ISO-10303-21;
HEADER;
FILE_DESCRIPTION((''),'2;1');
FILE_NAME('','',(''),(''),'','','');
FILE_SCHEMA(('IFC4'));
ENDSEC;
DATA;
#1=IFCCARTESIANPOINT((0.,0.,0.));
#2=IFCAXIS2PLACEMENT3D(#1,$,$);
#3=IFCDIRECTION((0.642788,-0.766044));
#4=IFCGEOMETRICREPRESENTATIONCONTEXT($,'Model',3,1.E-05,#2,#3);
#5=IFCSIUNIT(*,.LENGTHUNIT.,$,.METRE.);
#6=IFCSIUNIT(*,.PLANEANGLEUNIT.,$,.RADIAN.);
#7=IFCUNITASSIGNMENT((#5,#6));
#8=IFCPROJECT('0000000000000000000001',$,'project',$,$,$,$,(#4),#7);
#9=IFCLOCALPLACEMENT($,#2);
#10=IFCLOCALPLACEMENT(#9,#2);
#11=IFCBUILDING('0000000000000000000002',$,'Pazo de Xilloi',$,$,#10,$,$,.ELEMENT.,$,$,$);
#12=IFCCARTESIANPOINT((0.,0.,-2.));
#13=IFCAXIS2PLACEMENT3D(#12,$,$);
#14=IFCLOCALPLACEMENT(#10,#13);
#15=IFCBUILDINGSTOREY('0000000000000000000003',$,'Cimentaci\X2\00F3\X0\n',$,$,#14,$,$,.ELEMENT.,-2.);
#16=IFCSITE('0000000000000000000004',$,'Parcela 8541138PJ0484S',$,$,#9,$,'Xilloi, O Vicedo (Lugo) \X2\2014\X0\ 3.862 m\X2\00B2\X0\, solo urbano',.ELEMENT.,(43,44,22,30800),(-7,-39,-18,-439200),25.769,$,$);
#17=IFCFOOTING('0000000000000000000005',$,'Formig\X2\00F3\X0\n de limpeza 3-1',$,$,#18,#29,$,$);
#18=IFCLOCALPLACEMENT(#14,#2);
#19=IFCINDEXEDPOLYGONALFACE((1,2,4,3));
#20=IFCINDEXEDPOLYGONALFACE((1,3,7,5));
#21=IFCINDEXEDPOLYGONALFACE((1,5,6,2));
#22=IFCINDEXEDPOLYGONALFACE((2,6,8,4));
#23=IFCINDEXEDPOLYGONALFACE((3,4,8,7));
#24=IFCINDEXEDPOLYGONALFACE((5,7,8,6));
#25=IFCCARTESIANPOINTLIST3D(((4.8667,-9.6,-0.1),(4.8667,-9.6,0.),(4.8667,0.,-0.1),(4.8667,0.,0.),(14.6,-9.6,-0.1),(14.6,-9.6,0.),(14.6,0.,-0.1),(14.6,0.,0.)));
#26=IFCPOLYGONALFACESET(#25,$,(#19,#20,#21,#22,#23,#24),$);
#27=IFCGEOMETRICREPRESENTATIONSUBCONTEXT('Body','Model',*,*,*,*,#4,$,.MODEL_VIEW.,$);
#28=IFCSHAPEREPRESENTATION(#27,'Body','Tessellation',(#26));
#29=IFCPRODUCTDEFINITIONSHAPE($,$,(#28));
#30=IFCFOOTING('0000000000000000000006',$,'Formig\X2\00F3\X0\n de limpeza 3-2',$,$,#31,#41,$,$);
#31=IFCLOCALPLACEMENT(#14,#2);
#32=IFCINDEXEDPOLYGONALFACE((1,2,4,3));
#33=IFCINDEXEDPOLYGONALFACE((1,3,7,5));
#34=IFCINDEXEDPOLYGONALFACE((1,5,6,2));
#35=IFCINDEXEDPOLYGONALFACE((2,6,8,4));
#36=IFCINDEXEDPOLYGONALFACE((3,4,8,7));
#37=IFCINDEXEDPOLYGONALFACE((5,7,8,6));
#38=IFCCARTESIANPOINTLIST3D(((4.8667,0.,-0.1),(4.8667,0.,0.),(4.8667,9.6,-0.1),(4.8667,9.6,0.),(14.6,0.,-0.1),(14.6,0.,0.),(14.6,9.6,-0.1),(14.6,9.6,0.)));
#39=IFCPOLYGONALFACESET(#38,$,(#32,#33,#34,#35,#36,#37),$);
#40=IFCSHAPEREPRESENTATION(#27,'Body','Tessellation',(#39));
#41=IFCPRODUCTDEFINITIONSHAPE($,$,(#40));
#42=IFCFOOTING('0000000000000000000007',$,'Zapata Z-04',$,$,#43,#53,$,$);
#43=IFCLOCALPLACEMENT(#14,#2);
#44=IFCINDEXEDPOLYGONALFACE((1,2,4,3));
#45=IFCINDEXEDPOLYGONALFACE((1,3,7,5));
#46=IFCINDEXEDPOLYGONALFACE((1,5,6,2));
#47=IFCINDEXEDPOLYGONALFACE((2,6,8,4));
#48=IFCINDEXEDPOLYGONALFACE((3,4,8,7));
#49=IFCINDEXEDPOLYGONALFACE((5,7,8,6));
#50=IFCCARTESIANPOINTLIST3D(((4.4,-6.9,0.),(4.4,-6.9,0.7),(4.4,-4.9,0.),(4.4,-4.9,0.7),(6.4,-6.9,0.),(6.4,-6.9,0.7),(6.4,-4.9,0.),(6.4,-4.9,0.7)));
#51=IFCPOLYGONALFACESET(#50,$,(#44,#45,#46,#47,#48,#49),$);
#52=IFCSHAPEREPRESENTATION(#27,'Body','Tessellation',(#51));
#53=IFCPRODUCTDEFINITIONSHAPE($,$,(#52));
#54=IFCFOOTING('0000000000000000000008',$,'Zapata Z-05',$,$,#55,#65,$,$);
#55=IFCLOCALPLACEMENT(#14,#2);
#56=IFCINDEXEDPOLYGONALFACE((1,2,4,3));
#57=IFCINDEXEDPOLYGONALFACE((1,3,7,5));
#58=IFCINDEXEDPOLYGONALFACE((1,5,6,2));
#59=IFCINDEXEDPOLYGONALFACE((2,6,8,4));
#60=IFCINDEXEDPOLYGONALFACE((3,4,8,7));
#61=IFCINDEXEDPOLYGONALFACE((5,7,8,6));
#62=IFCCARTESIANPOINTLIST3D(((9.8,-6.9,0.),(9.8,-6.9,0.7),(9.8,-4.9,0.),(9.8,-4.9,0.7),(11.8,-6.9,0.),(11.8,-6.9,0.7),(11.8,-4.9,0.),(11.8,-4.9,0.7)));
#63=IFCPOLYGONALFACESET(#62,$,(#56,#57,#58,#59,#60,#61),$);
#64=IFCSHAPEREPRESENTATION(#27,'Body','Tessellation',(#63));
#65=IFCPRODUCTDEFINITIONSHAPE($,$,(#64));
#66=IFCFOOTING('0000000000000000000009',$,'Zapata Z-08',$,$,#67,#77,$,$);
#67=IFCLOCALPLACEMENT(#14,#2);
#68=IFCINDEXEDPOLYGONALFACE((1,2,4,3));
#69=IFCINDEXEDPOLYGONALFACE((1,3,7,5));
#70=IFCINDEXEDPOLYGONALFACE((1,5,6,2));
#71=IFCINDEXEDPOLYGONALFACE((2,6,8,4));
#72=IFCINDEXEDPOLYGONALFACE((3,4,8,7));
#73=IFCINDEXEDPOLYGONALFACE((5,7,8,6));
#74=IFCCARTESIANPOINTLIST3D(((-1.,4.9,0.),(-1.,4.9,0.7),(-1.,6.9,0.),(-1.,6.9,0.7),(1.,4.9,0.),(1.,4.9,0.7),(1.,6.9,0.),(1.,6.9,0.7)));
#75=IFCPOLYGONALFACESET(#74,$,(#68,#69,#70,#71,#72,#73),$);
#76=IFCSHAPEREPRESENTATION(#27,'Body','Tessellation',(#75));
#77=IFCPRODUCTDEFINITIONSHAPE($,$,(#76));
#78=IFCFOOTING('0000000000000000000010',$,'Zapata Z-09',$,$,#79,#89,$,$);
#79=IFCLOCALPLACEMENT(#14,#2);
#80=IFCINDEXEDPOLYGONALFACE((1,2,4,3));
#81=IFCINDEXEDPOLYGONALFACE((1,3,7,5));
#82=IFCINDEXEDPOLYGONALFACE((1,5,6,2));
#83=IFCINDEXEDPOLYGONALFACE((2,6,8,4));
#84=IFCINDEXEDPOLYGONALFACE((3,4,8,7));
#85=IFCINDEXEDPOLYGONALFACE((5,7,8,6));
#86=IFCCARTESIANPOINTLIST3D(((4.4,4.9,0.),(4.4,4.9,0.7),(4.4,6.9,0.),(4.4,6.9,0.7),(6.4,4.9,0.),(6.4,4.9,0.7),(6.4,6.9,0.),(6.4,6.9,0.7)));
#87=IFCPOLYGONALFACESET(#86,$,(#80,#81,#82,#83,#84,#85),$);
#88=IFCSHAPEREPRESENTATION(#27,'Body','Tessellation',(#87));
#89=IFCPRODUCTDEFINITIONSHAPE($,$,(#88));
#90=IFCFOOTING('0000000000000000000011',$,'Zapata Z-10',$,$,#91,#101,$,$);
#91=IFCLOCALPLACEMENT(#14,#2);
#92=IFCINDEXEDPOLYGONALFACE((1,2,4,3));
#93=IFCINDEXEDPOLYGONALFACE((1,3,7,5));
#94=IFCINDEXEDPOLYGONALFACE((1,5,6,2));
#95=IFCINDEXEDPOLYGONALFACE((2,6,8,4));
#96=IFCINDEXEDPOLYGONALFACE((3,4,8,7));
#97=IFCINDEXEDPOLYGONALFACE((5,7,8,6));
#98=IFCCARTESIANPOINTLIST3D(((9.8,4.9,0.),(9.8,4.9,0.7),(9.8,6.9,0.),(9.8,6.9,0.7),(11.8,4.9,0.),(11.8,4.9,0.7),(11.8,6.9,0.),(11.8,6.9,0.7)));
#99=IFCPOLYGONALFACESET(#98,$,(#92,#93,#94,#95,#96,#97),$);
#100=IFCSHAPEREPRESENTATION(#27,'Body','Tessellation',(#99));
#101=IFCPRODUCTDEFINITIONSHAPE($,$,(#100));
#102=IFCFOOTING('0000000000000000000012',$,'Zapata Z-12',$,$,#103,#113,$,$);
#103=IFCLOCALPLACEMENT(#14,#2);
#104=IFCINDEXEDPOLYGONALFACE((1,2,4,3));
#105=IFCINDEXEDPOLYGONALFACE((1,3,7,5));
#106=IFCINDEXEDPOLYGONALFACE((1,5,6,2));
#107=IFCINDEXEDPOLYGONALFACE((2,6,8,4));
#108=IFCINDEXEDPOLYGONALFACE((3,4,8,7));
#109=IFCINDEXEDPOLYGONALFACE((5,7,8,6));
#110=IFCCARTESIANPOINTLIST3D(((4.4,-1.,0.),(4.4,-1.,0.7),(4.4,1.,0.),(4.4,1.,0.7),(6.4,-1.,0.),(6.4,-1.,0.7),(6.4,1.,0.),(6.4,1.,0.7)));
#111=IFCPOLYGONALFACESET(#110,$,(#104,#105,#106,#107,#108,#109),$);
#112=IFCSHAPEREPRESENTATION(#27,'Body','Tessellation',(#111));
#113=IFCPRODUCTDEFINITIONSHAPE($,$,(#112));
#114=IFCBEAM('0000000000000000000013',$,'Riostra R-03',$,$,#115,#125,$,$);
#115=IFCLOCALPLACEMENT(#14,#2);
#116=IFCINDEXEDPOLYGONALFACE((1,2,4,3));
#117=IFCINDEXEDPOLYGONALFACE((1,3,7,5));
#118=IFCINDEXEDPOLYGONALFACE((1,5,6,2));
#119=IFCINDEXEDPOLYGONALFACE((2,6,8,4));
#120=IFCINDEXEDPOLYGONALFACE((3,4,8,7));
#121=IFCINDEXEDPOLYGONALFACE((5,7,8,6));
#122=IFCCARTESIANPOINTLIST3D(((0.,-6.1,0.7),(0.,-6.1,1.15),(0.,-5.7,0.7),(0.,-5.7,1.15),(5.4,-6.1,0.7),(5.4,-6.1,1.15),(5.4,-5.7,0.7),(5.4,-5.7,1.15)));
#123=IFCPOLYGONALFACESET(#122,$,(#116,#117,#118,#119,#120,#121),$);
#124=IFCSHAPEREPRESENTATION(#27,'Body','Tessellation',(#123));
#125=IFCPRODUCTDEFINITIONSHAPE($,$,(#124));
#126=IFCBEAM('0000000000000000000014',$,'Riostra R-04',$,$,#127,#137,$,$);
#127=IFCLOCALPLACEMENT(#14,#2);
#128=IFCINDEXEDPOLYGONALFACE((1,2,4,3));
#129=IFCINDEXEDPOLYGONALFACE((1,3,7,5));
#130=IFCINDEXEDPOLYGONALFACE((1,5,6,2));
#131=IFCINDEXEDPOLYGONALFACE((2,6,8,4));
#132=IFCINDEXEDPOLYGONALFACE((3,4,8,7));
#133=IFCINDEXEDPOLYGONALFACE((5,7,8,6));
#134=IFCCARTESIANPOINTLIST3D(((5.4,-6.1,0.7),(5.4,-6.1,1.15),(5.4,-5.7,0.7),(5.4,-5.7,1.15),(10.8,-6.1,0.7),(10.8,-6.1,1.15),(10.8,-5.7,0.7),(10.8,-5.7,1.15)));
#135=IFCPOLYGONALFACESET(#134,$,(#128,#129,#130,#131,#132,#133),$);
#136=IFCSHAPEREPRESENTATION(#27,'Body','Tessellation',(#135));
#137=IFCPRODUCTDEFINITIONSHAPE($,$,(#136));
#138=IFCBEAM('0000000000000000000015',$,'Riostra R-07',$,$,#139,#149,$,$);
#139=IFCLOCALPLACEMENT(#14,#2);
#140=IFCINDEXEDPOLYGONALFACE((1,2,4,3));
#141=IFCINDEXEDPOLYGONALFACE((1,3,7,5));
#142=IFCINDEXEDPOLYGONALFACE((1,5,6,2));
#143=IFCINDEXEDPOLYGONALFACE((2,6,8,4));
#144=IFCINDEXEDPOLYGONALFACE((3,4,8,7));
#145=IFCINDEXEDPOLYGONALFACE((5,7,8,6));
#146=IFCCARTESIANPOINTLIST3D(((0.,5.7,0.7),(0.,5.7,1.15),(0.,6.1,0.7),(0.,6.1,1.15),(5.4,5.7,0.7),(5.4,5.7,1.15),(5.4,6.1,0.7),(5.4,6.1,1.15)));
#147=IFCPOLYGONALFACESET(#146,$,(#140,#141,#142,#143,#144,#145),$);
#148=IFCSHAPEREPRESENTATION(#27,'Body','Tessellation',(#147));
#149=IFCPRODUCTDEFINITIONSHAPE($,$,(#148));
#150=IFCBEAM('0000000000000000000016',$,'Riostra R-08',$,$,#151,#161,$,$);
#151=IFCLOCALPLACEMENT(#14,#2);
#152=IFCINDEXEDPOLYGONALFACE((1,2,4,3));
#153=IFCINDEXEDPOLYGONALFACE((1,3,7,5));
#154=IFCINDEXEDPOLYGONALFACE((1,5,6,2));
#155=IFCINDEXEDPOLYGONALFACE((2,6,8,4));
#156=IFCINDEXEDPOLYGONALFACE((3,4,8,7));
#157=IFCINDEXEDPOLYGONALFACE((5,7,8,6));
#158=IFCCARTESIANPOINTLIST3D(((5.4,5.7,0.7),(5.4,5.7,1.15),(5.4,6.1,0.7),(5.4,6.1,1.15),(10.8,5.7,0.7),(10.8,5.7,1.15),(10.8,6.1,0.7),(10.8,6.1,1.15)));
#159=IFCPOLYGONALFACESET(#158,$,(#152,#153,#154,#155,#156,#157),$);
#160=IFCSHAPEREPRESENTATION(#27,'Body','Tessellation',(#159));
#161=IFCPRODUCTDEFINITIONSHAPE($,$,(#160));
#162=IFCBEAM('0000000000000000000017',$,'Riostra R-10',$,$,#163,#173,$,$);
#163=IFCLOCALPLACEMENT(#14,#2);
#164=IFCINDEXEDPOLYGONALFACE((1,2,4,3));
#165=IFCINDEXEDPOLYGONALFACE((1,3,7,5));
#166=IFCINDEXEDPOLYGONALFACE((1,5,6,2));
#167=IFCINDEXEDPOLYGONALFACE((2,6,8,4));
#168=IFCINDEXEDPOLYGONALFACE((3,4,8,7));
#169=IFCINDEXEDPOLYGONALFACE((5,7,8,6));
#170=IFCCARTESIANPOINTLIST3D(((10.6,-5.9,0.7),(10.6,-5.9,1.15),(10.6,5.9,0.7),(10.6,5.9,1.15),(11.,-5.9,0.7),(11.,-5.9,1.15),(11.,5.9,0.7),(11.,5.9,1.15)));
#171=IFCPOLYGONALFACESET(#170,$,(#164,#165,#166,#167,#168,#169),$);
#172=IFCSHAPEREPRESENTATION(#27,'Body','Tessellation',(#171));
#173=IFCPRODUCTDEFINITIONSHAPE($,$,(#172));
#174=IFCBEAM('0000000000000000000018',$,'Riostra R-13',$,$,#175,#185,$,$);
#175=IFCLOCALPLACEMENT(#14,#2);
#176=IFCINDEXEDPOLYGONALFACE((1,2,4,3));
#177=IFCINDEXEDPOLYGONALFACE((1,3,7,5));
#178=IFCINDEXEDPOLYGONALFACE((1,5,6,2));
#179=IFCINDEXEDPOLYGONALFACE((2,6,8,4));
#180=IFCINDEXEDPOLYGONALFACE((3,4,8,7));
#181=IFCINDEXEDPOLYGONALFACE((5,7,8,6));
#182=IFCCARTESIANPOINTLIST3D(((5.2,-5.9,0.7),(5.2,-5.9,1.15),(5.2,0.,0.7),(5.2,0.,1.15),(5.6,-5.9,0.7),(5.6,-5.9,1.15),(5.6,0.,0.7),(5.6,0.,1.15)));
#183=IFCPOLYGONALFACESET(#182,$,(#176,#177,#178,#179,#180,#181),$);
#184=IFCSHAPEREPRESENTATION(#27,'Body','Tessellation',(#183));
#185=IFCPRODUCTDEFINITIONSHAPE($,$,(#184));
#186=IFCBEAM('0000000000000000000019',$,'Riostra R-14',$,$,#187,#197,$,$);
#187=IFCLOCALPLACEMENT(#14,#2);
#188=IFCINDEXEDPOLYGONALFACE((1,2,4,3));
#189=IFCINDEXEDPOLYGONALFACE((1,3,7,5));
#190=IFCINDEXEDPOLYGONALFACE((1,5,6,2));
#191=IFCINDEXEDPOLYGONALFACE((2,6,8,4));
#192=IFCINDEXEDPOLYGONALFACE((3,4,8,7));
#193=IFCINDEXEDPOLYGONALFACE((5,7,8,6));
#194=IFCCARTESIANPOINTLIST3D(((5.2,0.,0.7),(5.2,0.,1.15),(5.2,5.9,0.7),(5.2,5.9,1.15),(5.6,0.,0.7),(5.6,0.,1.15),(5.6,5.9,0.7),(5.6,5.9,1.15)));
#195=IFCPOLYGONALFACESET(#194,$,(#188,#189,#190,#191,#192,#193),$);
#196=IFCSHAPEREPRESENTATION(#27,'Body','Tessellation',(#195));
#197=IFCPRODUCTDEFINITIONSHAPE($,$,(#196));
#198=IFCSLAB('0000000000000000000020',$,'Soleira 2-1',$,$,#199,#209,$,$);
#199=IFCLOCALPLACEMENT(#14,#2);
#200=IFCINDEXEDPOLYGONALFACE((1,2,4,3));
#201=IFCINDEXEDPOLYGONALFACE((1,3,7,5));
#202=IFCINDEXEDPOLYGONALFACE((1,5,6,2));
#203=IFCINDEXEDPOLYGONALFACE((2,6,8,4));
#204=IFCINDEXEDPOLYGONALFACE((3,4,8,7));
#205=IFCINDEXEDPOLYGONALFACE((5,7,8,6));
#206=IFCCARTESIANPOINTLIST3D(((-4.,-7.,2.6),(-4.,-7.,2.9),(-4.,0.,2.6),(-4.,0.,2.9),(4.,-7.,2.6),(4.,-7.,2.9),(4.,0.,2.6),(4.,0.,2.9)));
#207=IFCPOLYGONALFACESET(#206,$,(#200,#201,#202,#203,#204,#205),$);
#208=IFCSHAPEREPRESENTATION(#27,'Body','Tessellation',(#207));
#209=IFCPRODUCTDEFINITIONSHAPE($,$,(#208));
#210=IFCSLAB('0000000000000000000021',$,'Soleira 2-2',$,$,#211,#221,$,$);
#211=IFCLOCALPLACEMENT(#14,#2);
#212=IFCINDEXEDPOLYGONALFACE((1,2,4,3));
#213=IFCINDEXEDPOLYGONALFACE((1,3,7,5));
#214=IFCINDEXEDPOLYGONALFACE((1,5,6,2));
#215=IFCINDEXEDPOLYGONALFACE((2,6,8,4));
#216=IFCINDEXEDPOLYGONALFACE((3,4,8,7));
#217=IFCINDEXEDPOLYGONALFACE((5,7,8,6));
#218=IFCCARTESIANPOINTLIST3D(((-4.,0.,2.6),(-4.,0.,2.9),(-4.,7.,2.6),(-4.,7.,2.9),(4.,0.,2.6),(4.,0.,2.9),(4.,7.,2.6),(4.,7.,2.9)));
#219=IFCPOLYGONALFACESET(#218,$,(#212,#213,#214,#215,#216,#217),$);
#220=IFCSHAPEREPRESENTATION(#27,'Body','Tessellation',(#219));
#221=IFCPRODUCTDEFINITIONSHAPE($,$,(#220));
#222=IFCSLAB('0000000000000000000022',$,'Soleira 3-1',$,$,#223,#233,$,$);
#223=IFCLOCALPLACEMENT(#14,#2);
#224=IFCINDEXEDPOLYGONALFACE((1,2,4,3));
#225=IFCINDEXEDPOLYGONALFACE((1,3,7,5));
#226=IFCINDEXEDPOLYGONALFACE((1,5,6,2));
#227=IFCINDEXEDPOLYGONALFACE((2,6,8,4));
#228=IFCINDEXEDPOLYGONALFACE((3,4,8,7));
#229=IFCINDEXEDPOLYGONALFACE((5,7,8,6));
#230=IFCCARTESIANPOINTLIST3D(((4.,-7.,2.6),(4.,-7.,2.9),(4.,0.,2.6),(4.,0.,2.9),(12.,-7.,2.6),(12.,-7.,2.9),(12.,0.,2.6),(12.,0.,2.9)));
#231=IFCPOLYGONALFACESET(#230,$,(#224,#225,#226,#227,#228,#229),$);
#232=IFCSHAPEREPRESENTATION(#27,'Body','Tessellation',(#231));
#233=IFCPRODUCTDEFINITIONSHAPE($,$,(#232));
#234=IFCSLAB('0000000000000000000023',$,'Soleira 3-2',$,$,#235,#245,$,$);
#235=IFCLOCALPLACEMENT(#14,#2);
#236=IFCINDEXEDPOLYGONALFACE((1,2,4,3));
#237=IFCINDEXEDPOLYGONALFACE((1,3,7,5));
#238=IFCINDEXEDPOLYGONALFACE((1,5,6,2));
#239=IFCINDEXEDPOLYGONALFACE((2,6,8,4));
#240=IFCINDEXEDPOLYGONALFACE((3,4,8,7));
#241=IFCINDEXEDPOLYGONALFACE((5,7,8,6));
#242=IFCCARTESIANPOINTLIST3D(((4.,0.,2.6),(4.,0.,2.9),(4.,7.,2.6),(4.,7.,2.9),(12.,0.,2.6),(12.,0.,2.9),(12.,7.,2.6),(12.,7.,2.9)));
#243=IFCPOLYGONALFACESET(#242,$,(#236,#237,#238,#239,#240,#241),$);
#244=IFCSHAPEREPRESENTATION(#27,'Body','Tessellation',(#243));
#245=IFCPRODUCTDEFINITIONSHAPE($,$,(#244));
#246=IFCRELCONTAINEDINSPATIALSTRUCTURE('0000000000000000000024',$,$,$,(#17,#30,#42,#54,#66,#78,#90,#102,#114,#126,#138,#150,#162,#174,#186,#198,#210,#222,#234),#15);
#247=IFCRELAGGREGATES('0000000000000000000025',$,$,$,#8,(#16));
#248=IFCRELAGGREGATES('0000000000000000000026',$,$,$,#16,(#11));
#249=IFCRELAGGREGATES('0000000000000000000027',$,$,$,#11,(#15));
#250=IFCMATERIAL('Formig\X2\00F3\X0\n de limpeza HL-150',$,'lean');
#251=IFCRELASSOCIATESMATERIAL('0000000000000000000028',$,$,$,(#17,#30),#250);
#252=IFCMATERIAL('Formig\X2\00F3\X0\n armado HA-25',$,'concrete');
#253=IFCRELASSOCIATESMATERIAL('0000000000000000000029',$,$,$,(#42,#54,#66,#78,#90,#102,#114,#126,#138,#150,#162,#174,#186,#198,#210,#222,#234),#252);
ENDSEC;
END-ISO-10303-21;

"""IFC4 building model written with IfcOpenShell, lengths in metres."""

from ifc_helpers import new_model, si_unit, direction, frame, origin, origin_2d, place, context, subcontext, project, spatial, rectangle, extrude, material, element, save


model = new_model("IFC4")

# Units and contexts
model_context = context("Model", 3, precision=1e-05, world=origin(), true_north=direction((0.642788, -0.766044)))
body_context = subcontext(model_context, "Body", "Model", "MODEL_VIEW")
ifc_project = project(units=[si_unit("LENGTHUNIT", "METRE"), si_unit("PLANEANGLEUNIT", "RADIAN")], contexts=[model_context])

# Site, building, storey
site_placement = place(None, origin())
site = spatial("IfcSite", under=ifc_project, at=site_placement, Name="Parcela 8541138PJ0484S", LongName="Xilloi, O Vicedo (Lugo) — 3.862 m², solo urbano", CompositionType="ELEMENT", RefLatitude=(43, 44, 22, 30800), RefLongitude=(-7, -39, -18, -439200), RefElevation=25.769)
building_placement = place(site_placement, origin())
building = spatial("IfcBuilding", under=site, at=building_placement, Name="Pazo de Xilloi", CompositionType="ELEMENT")
storey_placement = place(building_placement, frame((0.0, 0.0, -2.0)))
storey = spatial("IfcBuildingStorey", under=building, at=storey_placement, Name="Cimentación", CompositionType="ELEMENT", Elevation=-2.0)

# Footings
ifc_material_1 = material(Name="Formigón de limpeza HL-150", Category="lean")
for number, where, name in (
    (1, (9.7333, -4.8, -0.05), "Formigón de limpeza 3-1"),
    (2, (9.7333, 4.8, -0.05), "Formigón de limpeza 3-2"),
):
    element("IfcFooting", number, at=place(storey_placement, frame(where)), inside=storey, material=ifc_material_1, Name=name, context=body_context, shape_type="SweptSolid", body=[
        extrude(rectangle(XDim=9.7333, YDim=9.6, at=origin_2d()), frame((0.0, 0.0, -0.05)), (0.0, 0.0, 1.0), 0.1),
    ])
ifc_material_2 = material(Name="Formigón armado HA-25", Category="concrete")
for number, where, name in (
    (3, (5.4, -5.9, 0.35), "Zapata Z-04"),
    (4, (10.8, -5.9, 0.35), "Zapata Z-05"),
    (5, (0.0, 5.9, 0.35), "Zapata Z-08"),
    (6, (5.4, 5.9, 0.35), "Zapata Z-09"),
    (7, (10.8, 5.9, 0.35), "Zapata Z-10"),
    (8, (5.4, 0.0, 0.35), "Zapata Z-12"),
):
    element("IfcFooting", number, at=place(storey_placement, frame(where)), inside=storey, material=ifc_material_2, Name=name, context=body_context, shape_type="SweptSolid", body=[
        extrude(rectangle(XDim=2.0, YDim=2.0, at=origin_2d()), frame((0.0, 0.0, -0.35)), (0.0, 0.0, 1.0), 0.7),
    ])

# Beams
for number, where, name in (
    (9, (2.7, -5.9, 0.925), "Riostra R-03"),
    (10, (8.1, -5.9, 0.925), "Riostra R-04"),
    (11, (2.7, 5.9, 0.925), "Riostra R-07"),
    (12, (8.1, 5.9, 0.925), "Riostra R-08"),
):
    element("IfcBeam", number, at=place(storey_placement, frame(where)), inside=storey, material=ifc_material_2, Name=name, context=body_context, shape_type="SweptSolid", body=[
        extrude(rectangle(XDim=5.4, YDim=0.4, at=origin_2d()), frame((0.0, 0.0, -0.225)), (0.0, 0.0, 1.0), 0.45),
    ])
beam_placement = place(storey_placement, frame((10.8, 0.0, 0.925)))
element("IfcBeam", 13, at=beam_placement, inside=storey, material=ifc_material_2, Name="Riostra R-10", context=body_context, shape_type="SweptSolid", body=[
    extrude(rectangle(XDim=0.4, YDim=11.8, at=origin_2d()), frame((0.0, 0.0, -0.225)), (0.0, 0.0, 1.0), 0.45),
])
for number, where, name in (
    (14, (5.4, -2.95, 0.925), "Riostra R-13"),
    (15, (5.4, 2.95, 0.925), "Riostra R-14"),
):
    element("IfcBeam", number, at=place(storey_placement, frame(where)), inside=storey, material=ifc_material_2, Name=name, context=body_context, shape_type="SweptSolid", body=[
        extrude(rectangle(XDim=0.4, YDim=5.9, at=origin_2d()), frame((0.0, 0.0, -0.225)), (0.0, 0.0, 1.0), 0.45),
    ])

# Slabs
for number, where, name in (
    (16, (0.0, -3.5, 2.75), "Soleira 2-1"),
    (17, (0.0, 3.5, 2.75), "Soleira 2-2"),
    (18, (8.0, -3.5, 2.75), "Soleira 3-1"),
    (19, (8.0, 3.5, 2.75), "Soleira 3-2"),
):
    element("IfcSlab", number, at=place(storey_placement, frame(where)), inside=storey, material=ifc_material_2, Name=name, context=body_context, shape_type="SweptSolid", body=[
        extrude(rectangle(XDim=8.0, YDim=7.0, at=origin_2d()), frame((0.0, 0.0, -0.15)), (0.0, 0.0, 1.0), 0.3),
    ])

save(model, "model.ifc")
